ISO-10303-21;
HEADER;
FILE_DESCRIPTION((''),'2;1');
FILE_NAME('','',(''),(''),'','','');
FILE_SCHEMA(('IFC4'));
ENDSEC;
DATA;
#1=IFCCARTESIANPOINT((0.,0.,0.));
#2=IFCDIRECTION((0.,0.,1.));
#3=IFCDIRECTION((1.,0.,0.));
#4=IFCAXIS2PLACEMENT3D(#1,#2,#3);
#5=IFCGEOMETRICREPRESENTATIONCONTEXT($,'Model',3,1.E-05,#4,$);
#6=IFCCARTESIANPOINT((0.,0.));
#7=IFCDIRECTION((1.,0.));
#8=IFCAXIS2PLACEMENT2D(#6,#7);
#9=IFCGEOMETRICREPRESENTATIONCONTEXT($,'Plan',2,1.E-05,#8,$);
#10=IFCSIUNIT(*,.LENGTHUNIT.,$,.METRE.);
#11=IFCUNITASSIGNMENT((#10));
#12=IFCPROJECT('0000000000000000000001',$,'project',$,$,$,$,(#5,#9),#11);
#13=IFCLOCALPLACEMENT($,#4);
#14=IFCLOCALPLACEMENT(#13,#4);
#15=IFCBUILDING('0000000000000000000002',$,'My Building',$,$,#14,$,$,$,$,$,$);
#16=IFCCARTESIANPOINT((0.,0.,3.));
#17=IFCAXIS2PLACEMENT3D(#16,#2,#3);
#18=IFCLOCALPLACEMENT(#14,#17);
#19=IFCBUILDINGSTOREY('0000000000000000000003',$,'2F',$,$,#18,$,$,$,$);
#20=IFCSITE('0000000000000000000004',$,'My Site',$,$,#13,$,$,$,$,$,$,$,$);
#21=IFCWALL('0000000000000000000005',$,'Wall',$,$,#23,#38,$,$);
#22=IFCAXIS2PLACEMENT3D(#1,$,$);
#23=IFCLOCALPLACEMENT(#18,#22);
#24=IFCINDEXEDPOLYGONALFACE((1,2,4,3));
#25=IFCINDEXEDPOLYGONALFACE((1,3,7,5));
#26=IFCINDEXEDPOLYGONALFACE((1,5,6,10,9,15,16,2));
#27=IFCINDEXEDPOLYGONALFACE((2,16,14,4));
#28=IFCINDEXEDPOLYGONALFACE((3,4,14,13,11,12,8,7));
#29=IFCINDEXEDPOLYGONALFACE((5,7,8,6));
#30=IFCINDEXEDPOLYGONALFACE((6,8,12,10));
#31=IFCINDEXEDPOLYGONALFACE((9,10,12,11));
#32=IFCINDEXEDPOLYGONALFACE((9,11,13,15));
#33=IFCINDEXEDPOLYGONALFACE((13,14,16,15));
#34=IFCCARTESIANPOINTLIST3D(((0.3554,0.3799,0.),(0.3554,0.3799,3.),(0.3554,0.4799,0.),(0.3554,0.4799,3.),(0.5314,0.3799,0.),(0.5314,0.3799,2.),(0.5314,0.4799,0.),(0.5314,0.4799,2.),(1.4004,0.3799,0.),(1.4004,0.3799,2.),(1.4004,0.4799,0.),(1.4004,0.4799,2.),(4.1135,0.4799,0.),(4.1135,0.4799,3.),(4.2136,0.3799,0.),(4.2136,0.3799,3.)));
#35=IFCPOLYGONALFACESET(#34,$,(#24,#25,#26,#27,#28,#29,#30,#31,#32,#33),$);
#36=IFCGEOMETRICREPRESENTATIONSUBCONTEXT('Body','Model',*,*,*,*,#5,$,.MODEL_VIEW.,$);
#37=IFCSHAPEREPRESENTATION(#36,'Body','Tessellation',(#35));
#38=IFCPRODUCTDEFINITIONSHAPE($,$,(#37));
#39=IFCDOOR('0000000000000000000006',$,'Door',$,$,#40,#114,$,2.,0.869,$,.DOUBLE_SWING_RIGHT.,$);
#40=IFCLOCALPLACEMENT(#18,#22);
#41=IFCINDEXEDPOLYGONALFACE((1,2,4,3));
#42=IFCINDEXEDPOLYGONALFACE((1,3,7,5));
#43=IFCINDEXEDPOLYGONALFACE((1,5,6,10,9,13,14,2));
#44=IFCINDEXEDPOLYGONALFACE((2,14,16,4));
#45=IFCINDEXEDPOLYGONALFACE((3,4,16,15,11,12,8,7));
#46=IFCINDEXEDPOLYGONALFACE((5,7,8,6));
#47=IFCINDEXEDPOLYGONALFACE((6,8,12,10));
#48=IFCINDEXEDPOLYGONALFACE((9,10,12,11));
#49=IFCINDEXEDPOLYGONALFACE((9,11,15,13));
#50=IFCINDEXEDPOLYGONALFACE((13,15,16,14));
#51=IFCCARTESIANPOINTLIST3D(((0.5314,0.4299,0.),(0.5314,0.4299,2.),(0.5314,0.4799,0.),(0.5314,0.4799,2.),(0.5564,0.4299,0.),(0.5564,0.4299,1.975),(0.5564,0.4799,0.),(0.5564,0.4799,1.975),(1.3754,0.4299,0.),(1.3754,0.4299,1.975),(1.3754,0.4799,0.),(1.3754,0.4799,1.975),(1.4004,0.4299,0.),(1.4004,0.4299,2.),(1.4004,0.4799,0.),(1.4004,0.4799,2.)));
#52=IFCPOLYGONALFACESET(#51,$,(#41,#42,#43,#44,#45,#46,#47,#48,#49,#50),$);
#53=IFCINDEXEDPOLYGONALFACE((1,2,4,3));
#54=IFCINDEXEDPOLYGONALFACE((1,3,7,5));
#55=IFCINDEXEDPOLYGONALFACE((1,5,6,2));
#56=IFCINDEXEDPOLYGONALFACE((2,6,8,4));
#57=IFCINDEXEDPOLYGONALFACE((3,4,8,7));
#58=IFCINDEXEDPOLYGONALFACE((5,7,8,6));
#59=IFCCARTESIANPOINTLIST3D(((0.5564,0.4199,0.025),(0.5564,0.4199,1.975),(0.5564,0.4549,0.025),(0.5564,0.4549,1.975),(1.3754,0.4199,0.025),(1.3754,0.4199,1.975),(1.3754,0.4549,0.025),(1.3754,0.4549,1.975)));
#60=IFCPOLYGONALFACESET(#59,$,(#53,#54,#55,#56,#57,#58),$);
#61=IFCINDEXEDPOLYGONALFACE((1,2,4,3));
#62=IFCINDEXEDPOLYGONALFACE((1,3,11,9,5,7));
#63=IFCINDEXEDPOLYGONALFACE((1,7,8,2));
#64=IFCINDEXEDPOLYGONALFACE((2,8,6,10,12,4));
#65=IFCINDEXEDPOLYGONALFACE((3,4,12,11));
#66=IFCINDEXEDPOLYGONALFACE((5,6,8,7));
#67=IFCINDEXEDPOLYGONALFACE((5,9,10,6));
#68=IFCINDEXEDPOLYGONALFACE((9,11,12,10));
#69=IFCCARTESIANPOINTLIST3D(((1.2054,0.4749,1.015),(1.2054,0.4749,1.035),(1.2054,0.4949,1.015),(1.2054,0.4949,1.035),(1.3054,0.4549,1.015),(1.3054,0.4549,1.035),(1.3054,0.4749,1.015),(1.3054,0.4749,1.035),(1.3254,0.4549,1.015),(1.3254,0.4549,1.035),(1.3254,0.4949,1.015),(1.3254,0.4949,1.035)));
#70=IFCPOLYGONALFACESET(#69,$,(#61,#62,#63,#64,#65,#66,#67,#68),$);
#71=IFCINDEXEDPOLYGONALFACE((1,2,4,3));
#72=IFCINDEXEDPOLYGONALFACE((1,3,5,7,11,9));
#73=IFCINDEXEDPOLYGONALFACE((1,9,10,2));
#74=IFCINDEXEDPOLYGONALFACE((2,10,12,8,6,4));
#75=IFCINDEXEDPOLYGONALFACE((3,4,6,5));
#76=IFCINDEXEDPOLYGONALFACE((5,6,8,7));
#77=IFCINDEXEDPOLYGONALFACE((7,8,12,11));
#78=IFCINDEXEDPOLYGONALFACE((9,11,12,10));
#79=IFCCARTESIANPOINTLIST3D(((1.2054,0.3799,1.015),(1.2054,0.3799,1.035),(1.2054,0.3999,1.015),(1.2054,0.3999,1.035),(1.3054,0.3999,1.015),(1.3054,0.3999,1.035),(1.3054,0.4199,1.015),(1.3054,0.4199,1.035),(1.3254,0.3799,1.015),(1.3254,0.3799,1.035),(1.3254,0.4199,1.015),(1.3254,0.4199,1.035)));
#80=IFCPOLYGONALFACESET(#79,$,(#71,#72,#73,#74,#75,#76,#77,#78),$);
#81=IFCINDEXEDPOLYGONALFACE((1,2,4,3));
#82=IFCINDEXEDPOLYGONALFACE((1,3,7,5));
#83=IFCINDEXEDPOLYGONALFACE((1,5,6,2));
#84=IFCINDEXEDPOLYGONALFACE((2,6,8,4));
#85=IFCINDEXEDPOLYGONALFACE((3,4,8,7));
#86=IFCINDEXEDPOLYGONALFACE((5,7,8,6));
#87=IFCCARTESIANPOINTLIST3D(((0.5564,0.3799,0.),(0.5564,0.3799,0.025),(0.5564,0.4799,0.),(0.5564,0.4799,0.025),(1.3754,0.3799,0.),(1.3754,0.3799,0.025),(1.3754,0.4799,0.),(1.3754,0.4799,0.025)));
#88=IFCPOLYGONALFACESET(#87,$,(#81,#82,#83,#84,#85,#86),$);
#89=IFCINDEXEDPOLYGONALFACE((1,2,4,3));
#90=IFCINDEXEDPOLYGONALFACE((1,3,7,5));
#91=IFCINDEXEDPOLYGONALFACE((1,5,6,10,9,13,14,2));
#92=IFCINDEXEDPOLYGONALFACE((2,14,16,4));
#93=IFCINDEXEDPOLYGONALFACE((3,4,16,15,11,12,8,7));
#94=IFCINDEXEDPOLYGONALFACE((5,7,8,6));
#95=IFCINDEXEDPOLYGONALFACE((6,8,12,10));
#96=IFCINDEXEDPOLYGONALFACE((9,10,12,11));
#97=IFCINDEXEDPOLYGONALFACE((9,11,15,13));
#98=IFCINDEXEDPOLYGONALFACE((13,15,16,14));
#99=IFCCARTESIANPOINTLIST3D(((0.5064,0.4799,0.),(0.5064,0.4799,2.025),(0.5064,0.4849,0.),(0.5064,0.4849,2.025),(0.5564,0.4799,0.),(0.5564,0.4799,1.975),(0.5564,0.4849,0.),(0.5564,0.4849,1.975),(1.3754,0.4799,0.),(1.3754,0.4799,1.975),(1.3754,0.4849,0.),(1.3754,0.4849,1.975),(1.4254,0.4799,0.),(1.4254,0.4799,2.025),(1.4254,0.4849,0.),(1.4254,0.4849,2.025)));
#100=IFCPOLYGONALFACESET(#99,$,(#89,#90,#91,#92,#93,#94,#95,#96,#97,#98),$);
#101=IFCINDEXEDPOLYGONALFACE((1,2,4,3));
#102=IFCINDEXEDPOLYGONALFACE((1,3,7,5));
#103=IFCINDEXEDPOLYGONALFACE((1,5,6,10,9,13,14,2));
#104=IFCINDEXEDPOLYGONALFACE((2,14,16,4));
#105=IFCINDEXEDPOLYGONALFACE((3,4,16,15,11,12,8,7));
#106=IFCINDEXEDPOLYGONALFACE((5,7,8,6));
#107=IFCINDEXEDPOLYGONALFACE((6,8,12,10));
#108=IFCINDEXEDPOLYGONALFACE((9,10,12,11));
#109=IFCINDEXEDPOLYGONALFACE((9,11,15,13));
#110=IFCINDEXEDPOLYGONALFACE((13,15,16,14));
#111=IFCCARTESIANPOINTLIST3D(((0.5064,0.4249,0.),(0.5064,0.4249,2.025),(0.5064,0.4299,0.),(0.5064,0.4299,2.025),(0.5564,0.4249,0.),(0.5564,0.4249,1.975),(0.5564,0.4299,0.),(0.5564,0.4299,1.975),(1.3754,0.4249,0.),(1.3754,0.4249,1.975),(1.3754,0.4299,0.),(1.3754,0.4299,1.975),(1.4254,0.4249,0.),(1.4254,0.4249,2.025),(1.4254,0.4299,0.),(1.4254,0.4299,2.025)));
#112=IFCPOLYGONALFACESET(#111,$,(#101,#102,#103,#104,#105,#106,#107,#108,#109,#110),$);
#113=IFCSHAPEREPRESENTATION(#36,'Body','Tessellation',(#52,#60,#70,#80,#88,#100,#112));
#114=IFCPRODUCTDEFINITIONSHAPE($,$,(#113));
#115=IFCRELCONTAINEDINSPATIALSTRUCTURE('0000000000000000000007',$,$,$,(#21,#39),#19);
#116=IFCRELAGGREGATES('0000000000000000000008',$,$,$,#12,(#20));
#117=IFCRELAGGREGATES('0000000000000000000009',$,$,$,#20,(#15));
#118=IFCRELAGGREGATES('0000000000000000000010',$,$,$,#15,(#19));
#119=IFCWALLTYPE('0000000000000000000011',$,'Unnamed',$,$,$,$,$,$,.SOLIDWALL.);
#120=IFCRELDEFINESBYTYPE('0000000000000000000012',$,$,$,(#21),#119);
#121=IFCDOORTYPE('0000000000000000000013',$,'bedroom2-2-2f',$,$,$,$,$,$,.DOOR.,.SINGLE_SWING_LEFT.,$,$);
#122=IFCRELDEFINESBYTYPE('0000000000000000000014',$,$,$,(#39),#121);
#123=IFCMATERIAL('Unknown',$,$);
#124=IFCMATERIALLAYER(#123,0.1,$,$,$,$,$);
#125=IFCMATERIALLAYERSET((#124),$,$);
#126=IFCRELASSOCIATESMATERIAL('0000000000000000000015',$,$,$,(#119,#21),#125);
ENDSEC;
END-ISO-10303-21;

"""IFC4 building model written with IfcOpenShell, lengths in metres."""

from ifc_helpers import new_model, entity, si_unit, frame, origin_with_axes, origin_2d_with_axis, place, context, subcontext, project, spatial, line, indexed_curve, outline, extrude, shape, source, transform, mapped, material, layer, layer_set, layer_usage, type_object, type_shapes, element, fill, save


model = new_model("IFC4")

# Units and contexts
model_context = context("Model", 3, precision=1e-05, world=origin_with_axes())
plan_context = context("Plan", 2, precision=1e-05, world=origin_2d_with_axis())
body_context_1 = subcontext(model_context, "Body", "Model", "MODEL_VIEW")
body_context_2 = subcontext(plan_context, "Body", "Plan", "PLAN_VIEW")
ifc_project = project(units=[si_unit("LENGTHUNIT", "METRE")], contexts=[model_context, plan_context])

# Site, building, storey
site_placement = place(None, origin_with_axes())
site = spatial("IfcSite", under=ifc_project, at=site_placement, Name="My Site")
building_placement = place(site_placement, origin_with_axes())
building = spatial("IfcBuilding", under=site, at=building_placement, Name="My Building")
storey_placement = place(building_placement, frame((0.0, 0.0, 3.0), z_axis=(0.0, 0.0, 1.0), x_axis=(1.0, 0.0, 0.0)))
storey = spatial("IfcBuildingStorey", under=building, at=storey_placement, Name="2F")

# Shared definitions
ifc_material = material(Name="Unknown")

# Shared definitions
ifc_layer_1 = layer(ifc_material, 0.1)
ifc_layer_set_1 = layer_set([ifc_layer_1])
wall_type = type_object("IfcWallType", Name="Unnamed", PredefinedType="SOLIDWALL", material=ifc_layer_set_1)

# Wall, opening, door
ifc_layer_usage_1 = layer_usage(ifc_layer_set_1, "AXIS2", "POSITIVE", 0.0)
wall_1_placement = place(storey_placement, frame((0.3554, 0.3799, 0.0), z_axis=(0.0, 0.0, 1.0), x_axis=(1.0, 0.0, 0.0)))
wall_1 = element("IfcWall", 1, at=wall_1_placement, inside=storey, type_object=wall_type, material=ifc_layer_usage_1, Name="Wall", context=body_context_1, shape_type="SweptSolid", body=[
    extrude(outline(indexed_curve([(0.0, 0.0), (0.0, 0.1), (3.7582, 0.1), (3.8582, 0.0)], segments=[line(1, 2, 3, 4, 1)])), origin_with_axes(), (0.0, 0.0, 1.0), 3.0),
])
shared_shape_1 = source(origin_with_axes(), body_context_1, "Body", "SweptSolid", [
    extrude(outline(indexed_curve([(0.0, 0.0), (0.869, 0.0), (0.869, 2.0), (0.0, 2.0)], segments=[line(1, 2, 3, 4, 1)])), frame((0.0, -0.6, 0.0), z_axis=(0.0, -1.0, 0.0), x_axis=(1.0, 0.0, 0.0)), (0.0, 0.0, -1.0), 1.2),
])
opening_1_placement = place(wall_1_placement, frame((1.045, 0.1, 0.0), z_axis=(0.0, 0.0, 1.0), x_axis=(-1.0, 0.000001, 0.0)))
opening_1 = element("IfcOpeningElement", 2, at=opening_1_placement, cuts=wall_1, PredefinedType="OPENING", context=body_context_1, shape_type="MappedRepresentation", body=[
    mapped(shared_shape_1, transform((0.0, 0.0, 0.0), x_axis=(1.0, 0.0, 0.0), y_axis=(0.0, 1.0, 0.0), z_axis=(0.0, 0.0, 1.0), scale=1.0)),
])
door_type_1 = type_object("IfcDoorType", Name="bedroom2-2-2f", OperationType="SINGLE_SWING_LEFT", PredefinedType="DOOR")
shared_shape_2 = source(origin_with_axes(), body_context_1, "Body", "SweptSolid", [
    extrude(outline(indexed_curve([(0.0, 0.0), (0.0, 2.0), (0.869, 2.0), (0.869, 0.0), (0.844, 0.0), (0.844, 1.975), (0.025, 1.975), (0.025, 0.0)], segments=[line(1, 2, 3, 4, 5, 6, 7, 8, 1)])), frame((0.0, 0.0, 0.0), z_axis=(0.0, -1.0, 0.0), x_axis=(1.0, 0.0, 0.0)), (0.0, 0.0, -1.0), 0.05),
    extrude(outline(indexed_curve([(0.0, 0.0), (0.819, 0.0), (0.819, 0.035), (0.0, 0.035)], segments=[line(1, 2, 3, 4, 1)])), frame((0.025, 0.025, 0.025), z_axis=(0.0, 0.0, 1.0), x_axis=(1.0, 0.0, 0.0)), (0.0, 0.0, 1.0), 1.95),
    extrude(outline(indexed_curve([(0.0, 0.0), (0.0, -0.04), (0.12, -0.04), (0.12, -0.02), (0.02, -0.02), (0.02, 0.0)], segments=[line(1, 2, 3, 4, 5, 6, 1)])), frame((0.075, 0.025, 1.015), z_axis=(0.0, 0.0, 1.0), x_axis=(1.0, 0.0, 0.0)), (0.0, 0.0, 1.0), 0.02),
    extrude(outline(indexed_curve([(0.0, 0.0), (0.0, 0.04), (0.12, 0.04), (0.12, 0.02), (0.02, 0.02), (0.02, 0.0)], segments=[line(1, 2, 3, 4, 5, 6, 1)])), frame((0.075, 0.06, 1.015), z_axis=(0.0, 0.0, 1.0), x_axis=(1.0, 0.0, 0.0)), (0.0, 0.0, 1.0), 0.02),
    extrude(outline(indexed_curve([(0.0, 0.0), (0.819, 0.0), (0.819, 0.1), (0.0, 0.1)], segments=[line(1, 2, 3, 4, 1)])), frame((0.025, 0.0, 0.0), z_axis=(0.0, 0.0, 1.0), x_axis=(1.0, 0.0, 0.0)), (0.0, 0.0, 1.0), 0.025),
    extrude(outline(indexed_curve([(0.0, 0.0), (0.0, 2.025), (0.919, 2.025), (0.919, 0.0), (0.869, 0.0), (0.869, 1.975), (0.05, 1.975), (0.05, 0.0)], segments=[line(1, 2, 3, 4, 5, 6, 7, 8, 1)])), frame((-0.025, -0.005, 0.0), z_axis=(0.0, -1.0, 0.0), x_axis=(1.0, 0.0, 0.0)), (0.0, 0.0, -1.0), 0.005),
    extrude(outline(indexed_curve([(0.0, 0.0), (0.0, 2.025), (0.919, 2.025), (0.919, 0.0), (0.869, 0.0), (0.869, 1.975), (0.05, 1.975), (0.05, 0.0)], segments=[line(1, 2, 3, 4, 5, 6, 7, 8, 1)])), frame((-0.025, 0.05, 0.0), z_axis=(0.0, -1.0, 0.0), x_axis=(1.0, 0.0, 0.0)), (0.0, 0.0, -1.0), 0.005),
])
shared_shape_3 = source(origin_with_axes(), body_context_2, "Body", "Curve2D", [
    entity("IfcIndexedPolyCurve", entity("IfcCartesianPointList2D", [[0.0, 0.0], [0.025, 0.0], [0.025, 0.05], [0.0, 0.05]]), [entity("IfcLineIndex", [1, 2, 3, 4, 1])]),
    entity("IfcIndexedPolyCurve", entity("IfcCartesianPointList2D", [[0.869, 0.0], [0.844, 0.0], [0.844, 0.05], [0.869, 0.05]]), [entity("IfcLineIndex", [1, 2, 3, 4, 1])]),
    entity("IfcIndexedPolyCurve", entity("IfcCartesianPointList2D", [[0.844, 0.05], [0.844, -0.769], [0.809, -0.769]])),
    entity("IfcTrimmedCurve", entity("IfcEllipse", entity("IfcAxis2Placement2D", entity("IfcCartesianPoint", [0.809, 0.05]), entity("IfcDirection", [1.0, 0.0])), 0.784, 0.819), [entity("IfcCartesianPoint", [0.809, 0.869])], [entity("IfcCartesianPoint", [0.809, -0.769])], True, "CARTESIAN"),
    entity("IfcIndexedPolyCurve", entity("IfcCartesianPointList2D", [[0.844, 0.05], [0.809, 0.05], [0.809, 0.869], [0.844, 0.869]]), [entity("IfcLineIndex", [1, 2, 3, 4, 1])]),
])
type_shapes(door_type_1, [shared_shape_2, shared_shape_3])
door_1_placement = place(opening_1_placement, frame((0.0, 0.0, 0.0), z_axis=(0.0, 0.0, 1.0), x_axis=(1.0, 0.0, 0.0)))
door_1 = element("IfcDoor", 3, at=door_1_placement, inside=storey, type_object=door_type_1, Name="Door", OperationType="DOUBLE_SWING_RIGHT", OverallHeight=2.0, OverallWidth=0.869, shapes=[
    shape(body_context_1, "Body", "MappedRepresentation", [mapped(shared_shape_2, transform((0.0, 0.0, 0.0), x_axis=(1.0, 0.0, 0.0), y_axis=(0.0, 1.0, 0.0), z_axis=(0.0, 0.0, 1.0), scale=1.0))]),
    shape(body_context_2, "Body", "MappedRepresentation", [mapped(shared_shape_3, transform((0.0, 0.0, 0.0), x_axis=(1.0, 0.0, 0.0), y_axis=(0.0, 1.0, 0.0), z_axis=(0.0, 0.0, 1.0), scale=1.0))]),
])
fill(opening_1, door_1)

save(model, "model.ifc")
